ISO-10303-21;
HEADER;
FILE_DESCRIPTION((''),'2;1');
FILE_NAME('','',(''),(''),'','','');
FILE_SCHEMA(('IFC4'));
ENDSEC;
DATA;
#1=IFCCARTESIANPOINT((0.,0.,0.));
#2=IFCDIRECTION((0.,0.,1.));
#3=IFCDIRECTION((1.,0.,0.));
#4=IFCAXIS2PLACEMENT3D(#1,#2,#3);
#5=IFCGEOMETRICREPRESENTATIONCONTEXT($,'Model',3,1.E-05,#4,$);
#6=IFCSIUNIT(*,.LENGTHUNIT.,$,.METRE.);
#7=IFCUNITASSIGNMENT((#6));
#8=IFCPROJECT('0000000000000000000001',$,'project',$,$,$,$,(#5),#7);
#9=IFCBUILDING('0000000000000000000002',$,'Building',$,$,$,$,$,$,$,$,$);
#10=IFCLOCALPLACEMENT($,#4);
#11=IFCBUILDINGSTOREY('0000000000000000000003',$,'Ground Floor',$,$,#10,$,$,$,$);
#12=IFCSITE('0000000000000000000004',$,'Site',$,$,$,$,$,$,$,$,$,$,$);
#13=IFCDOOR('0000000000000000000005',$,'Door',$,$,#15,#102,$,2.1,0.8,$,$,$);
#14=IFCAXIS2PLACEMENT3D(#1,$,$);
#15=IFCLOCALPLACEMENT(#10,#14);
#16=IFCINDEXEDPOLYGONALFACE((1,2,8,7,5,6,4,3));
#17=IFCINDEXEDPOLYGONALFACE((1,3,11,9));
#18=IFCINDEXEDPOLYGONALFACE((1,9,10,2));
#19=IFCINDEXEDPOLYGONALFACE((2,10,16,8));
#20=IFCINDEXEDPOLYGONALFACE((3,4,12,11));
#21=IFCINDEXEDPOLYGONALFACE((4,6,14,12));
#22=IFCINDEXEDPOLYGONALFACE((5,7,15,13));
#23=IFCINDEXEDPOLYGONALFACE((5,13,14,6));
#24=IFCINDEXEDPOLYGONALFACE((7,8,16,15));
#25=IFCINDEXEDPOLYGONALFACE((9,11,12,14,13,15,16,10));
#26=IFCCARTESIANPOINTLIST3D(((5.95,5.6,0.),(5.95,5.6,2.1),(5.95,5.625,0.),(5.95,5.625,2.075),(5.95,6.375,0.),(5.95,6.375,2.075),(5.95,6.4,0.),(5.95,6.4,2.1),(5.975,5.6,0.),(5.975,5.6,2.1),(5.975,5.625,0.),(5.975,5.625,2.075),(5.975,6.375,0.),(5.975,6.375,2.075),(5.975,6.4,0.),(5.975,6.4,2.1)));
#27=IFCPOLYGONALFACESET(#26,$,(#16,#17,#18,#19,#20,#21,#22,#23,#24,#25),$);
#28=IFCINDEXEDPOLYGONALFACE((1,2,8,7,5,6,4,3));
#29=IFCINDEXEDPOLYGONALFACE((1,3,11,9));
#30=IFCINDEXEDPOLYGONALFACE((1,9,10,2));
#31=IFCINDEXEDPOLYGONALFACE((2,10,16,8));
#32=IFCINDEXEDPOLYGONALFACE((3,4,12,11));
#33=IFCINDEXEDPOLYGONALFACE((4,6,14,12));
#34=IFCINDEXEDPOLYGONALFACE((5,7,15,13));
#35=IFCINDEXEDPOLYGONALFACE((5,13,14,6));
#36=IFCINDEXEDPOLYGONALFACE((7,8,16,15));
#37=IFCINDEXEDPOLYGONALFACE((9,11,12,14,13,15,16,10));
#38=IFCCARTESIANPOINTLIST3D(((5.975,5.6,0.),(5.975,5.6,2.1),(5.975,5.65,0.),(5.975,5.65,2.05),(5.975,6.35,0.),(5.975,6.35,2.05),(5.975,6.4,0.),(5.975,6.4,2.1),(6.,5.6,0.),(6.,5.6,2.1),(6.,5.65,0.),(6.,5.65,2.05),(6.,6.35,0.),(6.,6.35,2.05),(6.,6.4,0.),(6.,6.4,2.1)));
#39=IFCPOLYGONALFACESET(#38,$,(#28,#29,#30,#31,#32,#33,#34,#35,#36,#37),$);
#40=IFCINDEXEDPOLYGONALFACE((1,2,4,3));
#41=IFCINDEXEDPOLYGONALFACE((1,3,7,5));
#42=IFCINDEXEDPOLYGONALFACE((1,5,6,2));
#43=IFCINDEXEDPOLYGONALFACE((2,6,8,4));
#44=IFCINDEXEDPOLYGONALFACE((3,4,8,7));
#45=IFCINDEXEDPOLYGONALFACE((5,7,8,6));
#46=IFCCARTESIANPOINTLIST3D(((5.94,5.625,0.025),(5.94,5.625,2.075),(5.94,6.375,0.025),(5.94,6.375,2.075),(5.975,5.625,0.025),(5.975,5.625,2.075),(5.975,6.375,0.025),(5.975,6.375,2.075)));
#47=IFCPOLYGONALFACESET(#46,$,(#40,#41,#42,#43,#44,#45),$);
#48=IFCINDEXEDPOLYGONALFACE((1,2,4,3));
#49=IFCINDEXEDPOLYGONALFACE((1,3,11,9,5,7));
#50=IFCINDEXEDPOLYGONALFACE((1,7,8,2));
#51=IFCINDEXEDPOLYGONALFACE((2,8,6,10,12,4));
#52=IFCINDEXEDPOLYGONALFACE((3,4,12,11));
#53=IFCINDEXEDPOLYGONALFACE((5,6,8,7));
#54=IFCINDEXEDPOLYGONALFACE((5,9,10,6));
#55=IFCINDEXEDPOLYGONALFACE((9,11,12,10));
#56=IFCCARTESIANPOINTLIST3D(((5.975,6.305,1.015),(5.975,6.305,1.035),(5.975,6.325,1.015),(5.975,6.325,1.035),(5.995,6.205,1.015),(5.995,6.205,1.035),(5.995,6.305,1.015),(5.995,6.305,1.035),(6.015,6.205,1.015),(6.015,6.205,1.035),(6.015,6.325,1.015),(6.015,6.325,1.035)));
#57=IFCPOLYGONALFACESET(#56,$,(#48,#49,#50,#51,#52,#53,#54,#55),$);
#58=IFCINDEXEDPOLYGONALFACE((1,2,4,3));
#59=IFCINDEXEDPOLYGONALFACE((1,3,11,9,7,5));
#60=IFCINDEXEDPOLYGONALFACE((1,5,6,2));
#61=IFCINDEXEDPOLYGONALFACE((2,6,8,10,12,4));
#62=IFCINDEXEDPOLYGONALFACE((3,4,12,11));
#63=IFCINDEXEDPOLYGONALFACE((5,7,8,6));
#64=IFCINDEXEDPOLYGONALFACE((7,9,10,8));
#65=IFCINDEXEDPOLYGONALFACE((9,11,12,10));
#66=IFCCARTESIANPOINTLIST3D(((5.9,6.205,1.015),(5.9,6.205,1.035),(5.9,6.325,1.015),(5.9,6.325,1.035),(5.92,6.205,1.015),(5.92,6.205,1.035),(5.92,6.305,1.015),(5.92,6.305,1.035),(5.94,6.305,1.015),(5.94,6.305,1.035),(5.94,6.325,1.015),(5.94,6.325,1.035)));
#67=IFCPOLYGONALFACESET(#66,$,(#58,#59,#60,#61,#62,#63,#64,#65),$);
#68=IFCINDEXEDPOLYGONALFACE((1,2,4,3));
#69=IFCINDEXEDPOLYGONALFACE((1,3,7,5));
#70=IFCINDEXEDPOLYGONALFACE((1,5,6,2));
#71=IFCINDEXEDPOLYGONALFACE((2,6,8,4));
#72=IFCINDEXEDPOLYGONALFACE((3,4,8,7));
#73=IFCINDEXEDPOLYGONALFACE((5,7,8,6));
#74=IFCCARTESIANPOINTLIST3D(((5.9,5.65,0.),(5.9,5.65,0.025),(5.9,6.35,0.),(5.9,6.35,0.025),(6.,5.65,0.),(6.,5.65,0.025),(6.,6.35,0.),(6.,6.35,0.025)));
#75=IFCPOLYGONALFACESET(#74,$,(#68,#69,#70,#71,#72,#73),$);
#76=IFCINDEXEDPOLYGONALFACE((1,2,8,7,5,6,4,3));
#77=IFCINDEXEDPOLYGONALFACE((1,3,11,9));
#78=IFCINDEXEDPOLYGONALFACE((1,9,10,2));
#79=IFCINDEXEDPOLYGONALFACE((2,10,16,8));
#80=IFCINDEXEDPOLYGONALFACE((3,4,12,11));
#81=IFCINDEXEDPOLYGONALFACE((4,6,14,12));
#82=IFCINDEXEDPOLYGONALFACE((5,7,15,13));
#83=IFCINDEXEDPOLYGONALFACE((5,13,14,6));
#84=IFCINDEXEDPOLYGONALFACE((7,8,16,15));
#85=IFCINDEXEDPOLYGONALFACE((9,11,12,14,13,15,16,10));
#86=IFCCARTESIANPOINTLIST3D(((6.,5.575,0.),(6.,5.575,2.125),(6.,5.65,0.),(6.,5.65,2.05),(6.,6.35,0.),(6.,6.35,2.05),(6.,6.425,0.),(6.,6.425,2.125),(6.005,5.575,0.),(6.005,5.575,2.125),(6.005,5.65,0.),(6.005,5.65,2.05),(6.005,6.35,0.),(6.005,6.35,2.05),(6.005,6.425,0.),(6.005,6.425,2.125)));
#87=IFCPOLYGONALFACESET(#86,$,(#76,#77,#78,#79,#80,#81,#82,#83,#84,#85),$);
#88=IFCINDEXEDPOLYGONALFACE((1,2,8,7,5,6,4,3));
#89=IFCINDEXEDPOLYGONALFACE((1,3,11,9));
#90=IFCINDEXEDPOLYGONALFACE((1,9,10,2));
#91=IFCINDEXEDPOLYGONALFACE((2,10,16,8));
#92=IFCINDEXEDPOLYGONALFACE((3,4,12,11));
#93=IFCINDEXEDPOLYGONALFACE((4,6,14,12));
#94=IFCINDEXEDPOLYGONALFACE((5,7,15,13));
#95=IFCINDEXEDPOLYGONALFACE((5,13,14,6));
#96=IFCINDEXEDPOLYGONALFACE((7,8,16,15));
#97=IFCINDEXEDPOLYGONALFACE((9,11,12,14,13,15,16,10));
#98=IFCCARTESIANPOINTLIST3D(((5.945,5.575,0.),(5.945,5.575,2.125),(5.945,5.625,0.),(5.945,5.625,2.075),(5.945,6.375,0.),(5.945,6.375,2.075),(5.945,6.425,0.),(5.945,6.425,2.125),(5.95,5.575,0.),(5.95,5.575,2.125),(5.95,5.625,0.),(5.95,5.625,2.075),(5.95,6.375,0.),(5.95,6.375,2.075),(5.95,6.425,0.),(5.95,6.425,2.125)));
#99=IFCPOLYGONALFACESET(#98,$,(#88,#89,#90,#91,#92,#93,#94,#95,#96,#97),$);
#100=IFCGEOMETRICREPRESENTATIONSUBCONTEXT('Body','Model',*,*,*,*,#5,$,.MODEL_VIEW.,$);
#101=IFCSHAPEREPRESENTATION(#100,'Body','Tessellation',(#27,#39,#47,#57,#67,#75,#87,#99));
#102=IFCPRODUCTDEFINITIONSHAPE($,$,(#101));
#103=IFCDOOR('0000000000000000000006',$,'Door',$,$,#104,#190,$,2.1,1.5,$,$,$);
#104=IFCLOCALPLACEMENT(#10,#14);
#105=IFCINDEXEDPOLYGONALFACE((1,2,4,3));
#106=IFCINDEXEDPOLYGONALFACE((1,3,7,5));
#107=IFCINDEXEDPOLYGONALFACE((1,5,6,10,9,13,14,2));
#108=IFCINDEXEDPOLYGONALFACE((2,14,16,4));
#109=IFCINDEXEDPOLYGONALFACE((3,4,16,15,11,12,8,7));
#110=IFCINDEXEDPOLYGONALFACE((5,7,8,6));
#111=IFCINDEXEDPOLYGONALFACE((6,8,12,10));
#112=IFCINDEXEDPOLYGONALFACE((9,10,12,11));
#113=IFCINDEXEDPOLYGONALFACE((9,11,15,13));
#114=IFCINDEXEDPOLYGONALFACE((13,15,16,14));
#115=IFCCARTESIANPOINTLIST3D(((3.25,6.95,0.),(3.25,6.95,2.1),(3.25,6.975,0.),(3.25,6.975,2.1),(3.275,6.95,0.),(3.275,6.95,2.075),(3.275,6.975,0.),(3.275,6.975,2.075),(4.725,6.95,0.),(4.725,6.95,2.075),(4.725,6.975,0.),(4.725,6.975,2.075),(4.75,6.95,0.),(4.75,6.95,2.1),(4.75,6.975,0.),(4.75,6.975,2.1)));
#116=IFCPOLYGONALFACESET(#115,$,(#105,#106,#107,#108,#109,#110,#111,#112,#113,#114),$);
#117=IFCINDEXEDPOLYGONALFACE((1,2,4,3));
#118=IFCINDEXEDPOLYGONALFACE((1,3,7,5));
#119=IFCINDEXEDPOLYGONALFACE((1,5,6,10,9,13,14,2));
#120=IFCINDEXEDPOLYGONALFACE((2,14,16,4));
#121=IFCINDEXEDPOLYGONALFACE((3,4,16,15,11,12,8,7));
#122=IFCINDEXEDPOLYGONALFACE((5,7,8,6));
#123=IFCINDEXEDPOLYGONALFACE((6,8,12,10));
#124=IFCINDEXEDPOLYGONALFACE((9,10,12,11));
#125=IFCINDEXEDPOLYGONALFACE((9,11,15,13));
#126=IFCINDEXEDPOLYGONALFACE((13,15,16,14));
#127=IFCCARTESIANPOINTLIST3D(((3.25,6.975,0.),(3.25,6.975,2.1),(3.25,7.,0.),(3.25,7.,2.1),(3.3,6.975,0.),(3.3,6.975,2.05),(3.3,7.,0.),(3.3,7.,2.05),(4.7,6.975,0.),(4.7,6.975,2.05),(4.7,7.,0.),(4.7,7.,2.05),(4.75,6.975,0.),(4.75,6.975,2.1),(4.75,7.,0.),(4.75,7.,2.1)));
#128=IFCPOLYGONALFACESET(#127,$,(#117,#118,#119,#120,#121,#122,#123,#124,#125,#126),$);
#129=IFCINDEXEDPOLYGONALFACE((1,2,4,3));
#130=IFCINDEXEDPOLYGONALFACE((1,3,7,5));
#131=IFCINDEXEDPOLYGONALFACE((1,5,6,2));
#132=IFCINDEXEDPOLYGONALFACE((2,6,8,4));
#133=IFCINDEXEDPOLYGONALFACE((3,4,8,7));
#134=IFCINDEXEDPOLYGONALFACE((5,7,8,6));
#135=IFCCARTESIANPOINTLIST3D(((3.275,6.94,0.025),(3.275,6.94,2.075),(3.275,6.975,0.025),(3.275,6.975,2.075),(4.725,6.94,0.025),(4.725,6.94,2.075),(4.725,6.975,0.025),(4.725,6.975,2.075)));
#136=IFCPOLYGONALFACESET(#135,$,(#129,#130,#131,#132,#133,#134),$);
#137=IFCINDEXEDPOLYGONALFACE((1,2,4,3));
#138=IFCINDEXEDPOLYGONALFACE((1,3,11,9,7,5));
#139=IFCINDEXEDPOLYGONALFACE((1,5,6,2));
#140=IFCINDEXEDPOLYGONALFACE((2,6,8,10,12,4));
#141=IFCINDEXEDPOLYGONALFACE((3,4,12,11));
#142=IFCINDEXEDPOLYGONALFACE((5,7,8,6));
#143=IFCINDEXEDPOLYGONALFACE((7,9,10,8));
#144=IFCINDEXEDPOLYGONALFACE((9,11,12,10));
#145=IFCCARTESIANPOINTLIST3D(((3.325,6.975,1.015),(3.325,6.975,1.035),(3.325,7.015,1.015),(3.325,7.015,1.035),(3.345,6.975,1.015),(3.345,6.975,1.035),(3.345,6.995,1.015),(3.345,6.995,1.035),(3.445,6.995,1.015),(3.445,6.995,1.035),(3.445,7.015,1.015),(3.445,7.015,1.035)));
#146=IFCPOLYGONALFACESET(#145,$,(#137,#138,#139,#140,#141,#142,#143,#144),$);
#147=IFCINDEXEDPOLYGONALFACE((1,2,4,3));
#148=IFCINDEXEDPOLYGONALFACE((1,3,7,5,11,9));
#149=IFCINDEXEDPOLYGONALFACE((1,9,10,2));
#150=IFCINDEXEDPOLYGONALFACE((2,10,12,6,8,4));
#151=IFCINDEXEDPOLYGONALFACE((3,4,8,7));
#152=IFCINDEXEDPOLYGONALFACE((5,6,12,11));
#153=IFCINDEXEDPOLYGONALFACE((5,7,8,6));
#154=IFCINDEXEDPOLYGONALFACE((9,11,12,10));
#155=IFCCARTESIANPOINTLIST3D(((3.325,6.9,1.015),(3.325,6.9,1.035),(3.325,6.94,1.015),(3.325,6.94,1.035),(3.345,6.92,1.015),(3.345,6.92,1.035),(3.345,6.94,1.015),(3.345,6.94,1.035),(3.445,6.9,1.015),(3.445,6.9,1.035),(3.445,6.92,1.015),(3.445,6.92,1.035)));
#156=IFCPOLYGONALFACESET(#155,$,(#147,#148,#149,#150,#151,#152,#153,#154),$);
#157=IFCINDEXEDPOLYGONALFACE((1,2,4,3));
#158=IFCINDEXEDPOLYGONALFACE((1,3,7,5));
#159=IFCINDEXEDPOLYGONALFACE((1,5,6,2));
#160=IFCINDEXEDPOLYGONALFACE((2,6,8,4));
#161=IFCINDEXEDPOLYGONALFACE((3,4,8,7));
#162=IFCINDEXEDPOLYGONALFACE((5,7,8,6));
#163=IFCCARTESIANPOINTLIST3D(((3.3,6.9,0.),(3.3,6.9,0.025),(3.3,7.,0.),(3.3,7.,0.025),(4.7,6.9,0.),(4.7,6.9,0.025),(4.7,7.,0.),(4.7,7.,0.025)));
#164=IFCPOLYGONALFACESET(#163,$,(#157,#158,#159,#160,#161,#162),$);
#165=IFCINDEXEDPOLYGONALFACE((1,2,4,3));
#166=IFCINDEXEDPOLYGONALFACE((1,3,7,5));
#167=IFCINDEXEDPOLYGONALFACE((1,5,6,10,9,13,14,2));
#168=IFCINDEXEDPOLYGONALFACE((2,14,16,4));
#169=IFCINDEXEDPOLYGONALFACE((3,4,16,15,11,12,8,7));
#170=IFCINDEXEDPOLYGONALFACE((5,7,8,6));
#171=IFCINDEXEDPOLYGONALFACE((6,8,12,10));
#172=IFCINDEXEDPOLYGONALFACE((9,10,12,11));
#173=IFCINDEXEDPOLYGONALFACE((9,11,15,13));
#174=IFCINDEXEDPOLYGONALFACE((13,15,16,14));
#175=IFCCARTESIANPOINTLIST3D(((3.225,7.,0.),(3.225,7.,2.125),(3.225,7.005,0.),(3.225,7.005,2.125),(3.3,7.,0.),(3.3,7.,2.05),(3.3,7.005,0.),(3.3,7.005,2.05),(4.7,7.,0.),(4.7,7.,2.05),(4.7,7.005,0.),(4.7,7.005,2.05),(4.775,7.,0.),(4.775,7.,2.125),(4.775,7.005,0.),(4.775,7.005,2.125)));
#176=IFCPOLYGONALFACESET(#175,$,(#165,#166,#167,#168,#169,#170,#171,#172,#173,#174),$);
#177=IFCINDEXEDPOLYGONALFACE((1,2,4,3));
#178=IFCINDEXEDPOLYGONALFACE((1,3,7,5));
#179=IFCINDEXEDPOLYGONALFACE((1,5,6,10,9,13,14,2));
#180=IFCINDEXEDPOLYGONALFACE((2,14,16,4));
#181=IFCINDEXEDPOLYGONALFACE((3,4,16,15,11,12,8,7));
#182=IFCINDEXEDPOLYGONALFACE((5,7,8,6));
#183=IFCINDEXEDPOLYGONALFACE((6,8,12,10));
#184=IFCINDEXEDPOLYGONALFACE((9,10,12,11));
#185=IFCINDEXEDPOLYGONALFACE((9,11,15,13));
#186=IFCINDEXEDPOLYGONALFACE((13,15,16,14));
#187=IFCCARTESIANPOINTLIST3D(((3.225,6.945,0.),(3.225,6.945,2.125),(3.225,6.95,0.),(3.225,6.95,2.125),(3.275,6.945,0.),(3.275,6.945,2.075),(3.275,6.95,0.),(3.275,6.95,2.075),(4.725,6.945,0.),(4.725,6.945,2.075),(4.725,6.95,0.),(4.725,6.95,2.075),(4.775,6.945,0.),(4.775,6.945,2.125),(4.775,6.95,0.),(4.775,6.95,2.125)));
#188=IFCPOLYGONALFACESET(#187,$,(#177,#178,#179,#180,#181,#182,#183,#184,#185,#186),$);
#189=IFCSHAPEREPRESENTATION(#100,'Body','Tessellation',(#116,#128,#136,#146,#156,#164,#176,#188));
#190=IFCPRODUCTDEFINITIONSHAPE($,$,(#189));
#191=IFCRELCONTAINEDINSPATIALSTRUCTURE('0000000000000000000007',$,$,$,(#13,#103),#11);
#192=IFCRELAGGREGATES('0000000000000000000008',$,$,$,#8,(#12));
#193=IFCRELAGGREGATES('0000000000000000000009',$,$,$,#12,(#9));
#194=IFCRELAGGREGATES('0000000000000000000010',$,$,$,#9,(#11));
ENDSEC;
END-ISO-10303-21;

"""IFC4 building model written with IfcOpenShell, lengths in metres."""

from ifc_helpers import new_model, si_unit, frame, origin_with_axes, place, context, subcontext, project, spatial, line, indexed_curve, outline, extrude, element, save


model = new_model("IFC4")

# Units and contexts
model_context = context("Model", 3, precision=1e-05, world=origin_with_axes())
body_context = subcontext(model_context, "Body", "Model", "MODEL_VIEW")
ifc_project = project(units=[si_unit("LENGTHUNIT", "METRE")], contexts=[model_context])

# Site, building, storey
site = spatial("IfcSite", under=ifc_project, Name="Site")
building = spatial("IfcBuilding", under=site, Name="Building")
storey_placement = place(None, origin_with_axes())
storey = spatial("IfcBuildingStorey", under=building, at=storey_placement, Name="Ground Floor")

# Doors
door_1_placement = place(storey_placement, frame((6.0, 5.6, 0.0), z_axis=(0.0, 0.0, 1.0), x_axis=(0.0, 1.0, 0.0)))
element("IfcDoor", 1, at=door_1_placement, inside=storey, Name="Door", OverallHeight=2.1, OverallWidth=0.8, context=body_context, shape_type="SweptSolid", body=[
    extrude(outline(indexed_curve([(0.0, 0.0), (0.0, 2.1), (0.8, 2.1), (0.8, 0.0), (0.775, 0.0), (0.775, 2.075), (0.025, 2.075), (0.025, 0.0)], segments=[line(1, 2, 3, 4, 5, 6, 7, 8, 1)])), frame((0.0, 0.025, 0.0), z_axis=(0.0, -1.0, 0.0), x_axis=(1.0, 0.0, 0.0)), (0.0, 0.0, -1.0), 0.025),
    extrude(outline(indexed_curve([(0.0, 0.0), (0.0, 2.1), (0.8, 2.1), (0.8, 0.0), (0.75, 0.0), (0.75, 2.05), (0.05, 2.05), (0.05, 0.0)], segments=[line(1, 2, 3, 4, 5, 6, 7, 8, 1)])), frame((0.0, 0.0, 0.0), z_axis=(0.0, -1.0, 0.0), x_axis=(1.0, 0.0, 0.0)), (0.0, 0.0, -1.0), 0.025),
    extrude(outline(indexed_curve([(0.0, 0.0), (0.75, 0.0), (0.75, 0.035), (0.0, 0.035)], segments=[line(1, 2, 3, 4, 1)])), frame((0.025, 0.025, 0.025), z_axis=(0.0, 0.0, 1.0), x_axis=(1.0, 0.0, 0.0)), (0.0, 0.0, 1.0), 2.05),
    extrude(outline(indexed_curve([(0.0, 0.0), (0.0, -0.04), (-0.12, -0.04), (-0.12, -0.02), (-0.02, -0.02), (-0.02, 0.0)], segments=[line(1, 2, 3, 4, 5, 6, 1)])), frame((0.725, 0.025, 1.015), z_axis=(0.0, 0.0, 1.0), x_axis=(1.0, 0.0, 0.0)), (0.0, 0.0, 1.0), 0.02),
    extrude(outline(indexed_curve([(0.0, 0.0), (0.0, 0.04), (-0.12, 0.04), (-0.12, 0.02), (-0.02, 0.02), (-0.02, 0.0)], segments=[line(1, 2, 3, 4, 5, 6, 1)])), frame((0.725, 0.06, 1.015), z_axis=(0.0, 0.0, 1.0), x_axis=(1.0, 0.0, 0.0)), (0.0, 0.0, 1.0), 0.02),
    extrude(outline(indexed_curve([(0.0, 0.0), (0.7, 0.0), (0.7, 0.1), (0.0, 0.1)], segments=[line(1, 2, 3, 4, 1)])), frame((0.05, 0.0, 0.0), z_axis=(0.0, 0.0, 1.0), x_axis=(1.0, 0.0, 0.0)), (0.0, 0.0, 1.0), 0.025),
    extrude(outline(indexed_curve([(0.0, 0.0), (0.0, 2.125), (0.85, 2.125), (0.85, 0.0), (0.775, 0.0), (0.775, 2.05), (0.075, 2.05), (0.075, 0.0)], segments=[line(1, 2, 3, 4, 5, 6, 7, 8, 1)])), frame((-0.025, -0.005, 0.0), z_axis=(0.0, -1.0, 0.0), x_axis=(1.0, 0.0, 0.0)), (0.0, 0.0, -1.0), 0.005),
    extrude(outline(indexed_curve([(0.0, 0.0), (0.0, 2.125), (0.85, 2.125), (0.85, 0.0), (0.8, 0.0), (0.8, 2.075), (0.05, 2.075), (0.05, 0.0)], segments=[line(1, 2, 3, 4, 5, 6, 7, 8, 1)])), frame((-0.025, 0.05, 0.0), z_axis=(0.0, -1.0, 0.0), x_axis=(1.0, 0.0, 0.0)), (0.0, 0.0, -1.0), 0.005),
])
door_2_placement = place(storey_placement, frame((4.75, 7.0, 0.0), z_axis=(0.0, 0.0, 1.0), x_axis=(-1.0, 0.0, 0.0)))
element("IfcDoor", 2, at=door_2_placement, inside=storey, Name="Door", OverallHeight=2.1, OverallWidth=1.5, context=body_context, shape_type="SweptSolid", body=[
    extrude(outline(indexed_curve([(0.0, 0.0), (0.0, 2.1), (1.5, 2.1), (1.5, 0.0), (1.475, 0.0), (1.475, 2.075), (0.025, 2.075), (0.025, 0.0)], segments=[line(1, 2, 3, 4, 5, 6, 7, 8, 1)])), frame((0.0, 0.025, 0.0), z_axis=(0.0, -1.0, 0.0), x_axis=(1.0, 0.0, 0.0)), (0.0, 0.0, -1.0), 0.025),
    extrude(outline(indexed_curve([(0.0, 0.0), (0.0, 2.1), (1.5, 2.1), (1.5, 0.0), (1.45, 0.0), (1.45, 2.05), (0.05, 2.05), (0.05, 0.0)], segments=[line(1, 2, 3, 4, 5, 6, 7, 8, 1)])), frame((0.0, 0.0, 0.0), z_axis=(0.0, -1.0, 0.0), x_axis=(1.0, 0.0, 0.0)), (0.0, 0.0, -1.0), 0.025),
    extrude(outline(indexed_curve([(0.0, 0.0), (1.45, 0.0), (1.45, 0.035), (0.0, 0.035)], segments=[line(1, 2, 3, 4, 1)])), frame((0.025, 0.025, 0.025), z_axis=(0.0, 0.0, 1.0), x_axis=(1.0, 0.0, 0.0)), (0.0, 0.0, 1.0), 2.05),
    extrude(outline(indexed_curve([(0.0, 0.0), (0.0, -0.04), (-0.12, -0.04), (-0.12, -0.02), (-0.02, -0.02), (-0.02, 0.0)], segments=[line(1, 2, 3, 4, 5, 6, 1)])), frame((1.425, 0.025, 1.015), z_axis=(0.0, 0.0, 1.0), x_axis=(1.0, 0.0, 0.0)), (0.0, 0.0, 1.0), 0.02),
    extrude(outline(indexed_curve([(0.0, 0.0), (0.0, 0.04), (-0.12, 0.04), (-0.12, 0.02), (-0.02, 0.02), (-0.02, 0.0)], segments=[line(1, 2, 3, 4, 5, 6, 1)])), frame((1.425, 0.06, 1.015), z_axis=(0.0, 0.0, 1.0), x_axis=(1.0, 0.0, 0.0)), (0.0, 0.0, 1.0), 0.02),
    extrude(outline(indexed_curve([(0.0, 0.0), (1.4, 0.0), (1.4, 0.1), (0.0, 0.1)], segments=[line(1, 2, 3, 4, 1)])), frame((0.05, 0.0, 0.0), z_axis=(0.0, 0.0, 1.0), x_axis=(1.0, 0.0, 0.0)), (0.0, 0.0, 1.0), 0.025),
    extrude(outline(indexed_curve([(0.0, 0.0), (0.0, 2.125), (1.55, 2.125), (1.55, 0.0), (1.475, 0.0), (1.475, 2.05), (0.075, 2.05), (0.075, 0.0)], segments=[line(1, 2, 3, 4, 5, 6, 7, 8, 1)])), frame((-0.025, -0.005, 0.0), z_axis=(0.0, -1.0, 0.0), x_axis=(1.0, 0.0, 0.0)), (0.0, 0.0, -1.0), 0.005),
    extrude(outline(indexed_curve([(0.0, 0.0), (0.0, 2.125), (1.55, 2.125), (1.55, 0.0), (1.5, 0.0), (1.5, 2.075), (0.05, 2.075), (0.05, 0.0)], segments=[line(1, 2, 3, 4, 5, 6, 7, 8, 1)])), frame((-0.025, 0.05, 0.0), z_axis=(0.0, -1.0, 0.0), x_axis=(1.0, 0.0, 0.0)), (0.0, 0.0, -1.0), 0.005),
])

save(model, "model.ifc")
